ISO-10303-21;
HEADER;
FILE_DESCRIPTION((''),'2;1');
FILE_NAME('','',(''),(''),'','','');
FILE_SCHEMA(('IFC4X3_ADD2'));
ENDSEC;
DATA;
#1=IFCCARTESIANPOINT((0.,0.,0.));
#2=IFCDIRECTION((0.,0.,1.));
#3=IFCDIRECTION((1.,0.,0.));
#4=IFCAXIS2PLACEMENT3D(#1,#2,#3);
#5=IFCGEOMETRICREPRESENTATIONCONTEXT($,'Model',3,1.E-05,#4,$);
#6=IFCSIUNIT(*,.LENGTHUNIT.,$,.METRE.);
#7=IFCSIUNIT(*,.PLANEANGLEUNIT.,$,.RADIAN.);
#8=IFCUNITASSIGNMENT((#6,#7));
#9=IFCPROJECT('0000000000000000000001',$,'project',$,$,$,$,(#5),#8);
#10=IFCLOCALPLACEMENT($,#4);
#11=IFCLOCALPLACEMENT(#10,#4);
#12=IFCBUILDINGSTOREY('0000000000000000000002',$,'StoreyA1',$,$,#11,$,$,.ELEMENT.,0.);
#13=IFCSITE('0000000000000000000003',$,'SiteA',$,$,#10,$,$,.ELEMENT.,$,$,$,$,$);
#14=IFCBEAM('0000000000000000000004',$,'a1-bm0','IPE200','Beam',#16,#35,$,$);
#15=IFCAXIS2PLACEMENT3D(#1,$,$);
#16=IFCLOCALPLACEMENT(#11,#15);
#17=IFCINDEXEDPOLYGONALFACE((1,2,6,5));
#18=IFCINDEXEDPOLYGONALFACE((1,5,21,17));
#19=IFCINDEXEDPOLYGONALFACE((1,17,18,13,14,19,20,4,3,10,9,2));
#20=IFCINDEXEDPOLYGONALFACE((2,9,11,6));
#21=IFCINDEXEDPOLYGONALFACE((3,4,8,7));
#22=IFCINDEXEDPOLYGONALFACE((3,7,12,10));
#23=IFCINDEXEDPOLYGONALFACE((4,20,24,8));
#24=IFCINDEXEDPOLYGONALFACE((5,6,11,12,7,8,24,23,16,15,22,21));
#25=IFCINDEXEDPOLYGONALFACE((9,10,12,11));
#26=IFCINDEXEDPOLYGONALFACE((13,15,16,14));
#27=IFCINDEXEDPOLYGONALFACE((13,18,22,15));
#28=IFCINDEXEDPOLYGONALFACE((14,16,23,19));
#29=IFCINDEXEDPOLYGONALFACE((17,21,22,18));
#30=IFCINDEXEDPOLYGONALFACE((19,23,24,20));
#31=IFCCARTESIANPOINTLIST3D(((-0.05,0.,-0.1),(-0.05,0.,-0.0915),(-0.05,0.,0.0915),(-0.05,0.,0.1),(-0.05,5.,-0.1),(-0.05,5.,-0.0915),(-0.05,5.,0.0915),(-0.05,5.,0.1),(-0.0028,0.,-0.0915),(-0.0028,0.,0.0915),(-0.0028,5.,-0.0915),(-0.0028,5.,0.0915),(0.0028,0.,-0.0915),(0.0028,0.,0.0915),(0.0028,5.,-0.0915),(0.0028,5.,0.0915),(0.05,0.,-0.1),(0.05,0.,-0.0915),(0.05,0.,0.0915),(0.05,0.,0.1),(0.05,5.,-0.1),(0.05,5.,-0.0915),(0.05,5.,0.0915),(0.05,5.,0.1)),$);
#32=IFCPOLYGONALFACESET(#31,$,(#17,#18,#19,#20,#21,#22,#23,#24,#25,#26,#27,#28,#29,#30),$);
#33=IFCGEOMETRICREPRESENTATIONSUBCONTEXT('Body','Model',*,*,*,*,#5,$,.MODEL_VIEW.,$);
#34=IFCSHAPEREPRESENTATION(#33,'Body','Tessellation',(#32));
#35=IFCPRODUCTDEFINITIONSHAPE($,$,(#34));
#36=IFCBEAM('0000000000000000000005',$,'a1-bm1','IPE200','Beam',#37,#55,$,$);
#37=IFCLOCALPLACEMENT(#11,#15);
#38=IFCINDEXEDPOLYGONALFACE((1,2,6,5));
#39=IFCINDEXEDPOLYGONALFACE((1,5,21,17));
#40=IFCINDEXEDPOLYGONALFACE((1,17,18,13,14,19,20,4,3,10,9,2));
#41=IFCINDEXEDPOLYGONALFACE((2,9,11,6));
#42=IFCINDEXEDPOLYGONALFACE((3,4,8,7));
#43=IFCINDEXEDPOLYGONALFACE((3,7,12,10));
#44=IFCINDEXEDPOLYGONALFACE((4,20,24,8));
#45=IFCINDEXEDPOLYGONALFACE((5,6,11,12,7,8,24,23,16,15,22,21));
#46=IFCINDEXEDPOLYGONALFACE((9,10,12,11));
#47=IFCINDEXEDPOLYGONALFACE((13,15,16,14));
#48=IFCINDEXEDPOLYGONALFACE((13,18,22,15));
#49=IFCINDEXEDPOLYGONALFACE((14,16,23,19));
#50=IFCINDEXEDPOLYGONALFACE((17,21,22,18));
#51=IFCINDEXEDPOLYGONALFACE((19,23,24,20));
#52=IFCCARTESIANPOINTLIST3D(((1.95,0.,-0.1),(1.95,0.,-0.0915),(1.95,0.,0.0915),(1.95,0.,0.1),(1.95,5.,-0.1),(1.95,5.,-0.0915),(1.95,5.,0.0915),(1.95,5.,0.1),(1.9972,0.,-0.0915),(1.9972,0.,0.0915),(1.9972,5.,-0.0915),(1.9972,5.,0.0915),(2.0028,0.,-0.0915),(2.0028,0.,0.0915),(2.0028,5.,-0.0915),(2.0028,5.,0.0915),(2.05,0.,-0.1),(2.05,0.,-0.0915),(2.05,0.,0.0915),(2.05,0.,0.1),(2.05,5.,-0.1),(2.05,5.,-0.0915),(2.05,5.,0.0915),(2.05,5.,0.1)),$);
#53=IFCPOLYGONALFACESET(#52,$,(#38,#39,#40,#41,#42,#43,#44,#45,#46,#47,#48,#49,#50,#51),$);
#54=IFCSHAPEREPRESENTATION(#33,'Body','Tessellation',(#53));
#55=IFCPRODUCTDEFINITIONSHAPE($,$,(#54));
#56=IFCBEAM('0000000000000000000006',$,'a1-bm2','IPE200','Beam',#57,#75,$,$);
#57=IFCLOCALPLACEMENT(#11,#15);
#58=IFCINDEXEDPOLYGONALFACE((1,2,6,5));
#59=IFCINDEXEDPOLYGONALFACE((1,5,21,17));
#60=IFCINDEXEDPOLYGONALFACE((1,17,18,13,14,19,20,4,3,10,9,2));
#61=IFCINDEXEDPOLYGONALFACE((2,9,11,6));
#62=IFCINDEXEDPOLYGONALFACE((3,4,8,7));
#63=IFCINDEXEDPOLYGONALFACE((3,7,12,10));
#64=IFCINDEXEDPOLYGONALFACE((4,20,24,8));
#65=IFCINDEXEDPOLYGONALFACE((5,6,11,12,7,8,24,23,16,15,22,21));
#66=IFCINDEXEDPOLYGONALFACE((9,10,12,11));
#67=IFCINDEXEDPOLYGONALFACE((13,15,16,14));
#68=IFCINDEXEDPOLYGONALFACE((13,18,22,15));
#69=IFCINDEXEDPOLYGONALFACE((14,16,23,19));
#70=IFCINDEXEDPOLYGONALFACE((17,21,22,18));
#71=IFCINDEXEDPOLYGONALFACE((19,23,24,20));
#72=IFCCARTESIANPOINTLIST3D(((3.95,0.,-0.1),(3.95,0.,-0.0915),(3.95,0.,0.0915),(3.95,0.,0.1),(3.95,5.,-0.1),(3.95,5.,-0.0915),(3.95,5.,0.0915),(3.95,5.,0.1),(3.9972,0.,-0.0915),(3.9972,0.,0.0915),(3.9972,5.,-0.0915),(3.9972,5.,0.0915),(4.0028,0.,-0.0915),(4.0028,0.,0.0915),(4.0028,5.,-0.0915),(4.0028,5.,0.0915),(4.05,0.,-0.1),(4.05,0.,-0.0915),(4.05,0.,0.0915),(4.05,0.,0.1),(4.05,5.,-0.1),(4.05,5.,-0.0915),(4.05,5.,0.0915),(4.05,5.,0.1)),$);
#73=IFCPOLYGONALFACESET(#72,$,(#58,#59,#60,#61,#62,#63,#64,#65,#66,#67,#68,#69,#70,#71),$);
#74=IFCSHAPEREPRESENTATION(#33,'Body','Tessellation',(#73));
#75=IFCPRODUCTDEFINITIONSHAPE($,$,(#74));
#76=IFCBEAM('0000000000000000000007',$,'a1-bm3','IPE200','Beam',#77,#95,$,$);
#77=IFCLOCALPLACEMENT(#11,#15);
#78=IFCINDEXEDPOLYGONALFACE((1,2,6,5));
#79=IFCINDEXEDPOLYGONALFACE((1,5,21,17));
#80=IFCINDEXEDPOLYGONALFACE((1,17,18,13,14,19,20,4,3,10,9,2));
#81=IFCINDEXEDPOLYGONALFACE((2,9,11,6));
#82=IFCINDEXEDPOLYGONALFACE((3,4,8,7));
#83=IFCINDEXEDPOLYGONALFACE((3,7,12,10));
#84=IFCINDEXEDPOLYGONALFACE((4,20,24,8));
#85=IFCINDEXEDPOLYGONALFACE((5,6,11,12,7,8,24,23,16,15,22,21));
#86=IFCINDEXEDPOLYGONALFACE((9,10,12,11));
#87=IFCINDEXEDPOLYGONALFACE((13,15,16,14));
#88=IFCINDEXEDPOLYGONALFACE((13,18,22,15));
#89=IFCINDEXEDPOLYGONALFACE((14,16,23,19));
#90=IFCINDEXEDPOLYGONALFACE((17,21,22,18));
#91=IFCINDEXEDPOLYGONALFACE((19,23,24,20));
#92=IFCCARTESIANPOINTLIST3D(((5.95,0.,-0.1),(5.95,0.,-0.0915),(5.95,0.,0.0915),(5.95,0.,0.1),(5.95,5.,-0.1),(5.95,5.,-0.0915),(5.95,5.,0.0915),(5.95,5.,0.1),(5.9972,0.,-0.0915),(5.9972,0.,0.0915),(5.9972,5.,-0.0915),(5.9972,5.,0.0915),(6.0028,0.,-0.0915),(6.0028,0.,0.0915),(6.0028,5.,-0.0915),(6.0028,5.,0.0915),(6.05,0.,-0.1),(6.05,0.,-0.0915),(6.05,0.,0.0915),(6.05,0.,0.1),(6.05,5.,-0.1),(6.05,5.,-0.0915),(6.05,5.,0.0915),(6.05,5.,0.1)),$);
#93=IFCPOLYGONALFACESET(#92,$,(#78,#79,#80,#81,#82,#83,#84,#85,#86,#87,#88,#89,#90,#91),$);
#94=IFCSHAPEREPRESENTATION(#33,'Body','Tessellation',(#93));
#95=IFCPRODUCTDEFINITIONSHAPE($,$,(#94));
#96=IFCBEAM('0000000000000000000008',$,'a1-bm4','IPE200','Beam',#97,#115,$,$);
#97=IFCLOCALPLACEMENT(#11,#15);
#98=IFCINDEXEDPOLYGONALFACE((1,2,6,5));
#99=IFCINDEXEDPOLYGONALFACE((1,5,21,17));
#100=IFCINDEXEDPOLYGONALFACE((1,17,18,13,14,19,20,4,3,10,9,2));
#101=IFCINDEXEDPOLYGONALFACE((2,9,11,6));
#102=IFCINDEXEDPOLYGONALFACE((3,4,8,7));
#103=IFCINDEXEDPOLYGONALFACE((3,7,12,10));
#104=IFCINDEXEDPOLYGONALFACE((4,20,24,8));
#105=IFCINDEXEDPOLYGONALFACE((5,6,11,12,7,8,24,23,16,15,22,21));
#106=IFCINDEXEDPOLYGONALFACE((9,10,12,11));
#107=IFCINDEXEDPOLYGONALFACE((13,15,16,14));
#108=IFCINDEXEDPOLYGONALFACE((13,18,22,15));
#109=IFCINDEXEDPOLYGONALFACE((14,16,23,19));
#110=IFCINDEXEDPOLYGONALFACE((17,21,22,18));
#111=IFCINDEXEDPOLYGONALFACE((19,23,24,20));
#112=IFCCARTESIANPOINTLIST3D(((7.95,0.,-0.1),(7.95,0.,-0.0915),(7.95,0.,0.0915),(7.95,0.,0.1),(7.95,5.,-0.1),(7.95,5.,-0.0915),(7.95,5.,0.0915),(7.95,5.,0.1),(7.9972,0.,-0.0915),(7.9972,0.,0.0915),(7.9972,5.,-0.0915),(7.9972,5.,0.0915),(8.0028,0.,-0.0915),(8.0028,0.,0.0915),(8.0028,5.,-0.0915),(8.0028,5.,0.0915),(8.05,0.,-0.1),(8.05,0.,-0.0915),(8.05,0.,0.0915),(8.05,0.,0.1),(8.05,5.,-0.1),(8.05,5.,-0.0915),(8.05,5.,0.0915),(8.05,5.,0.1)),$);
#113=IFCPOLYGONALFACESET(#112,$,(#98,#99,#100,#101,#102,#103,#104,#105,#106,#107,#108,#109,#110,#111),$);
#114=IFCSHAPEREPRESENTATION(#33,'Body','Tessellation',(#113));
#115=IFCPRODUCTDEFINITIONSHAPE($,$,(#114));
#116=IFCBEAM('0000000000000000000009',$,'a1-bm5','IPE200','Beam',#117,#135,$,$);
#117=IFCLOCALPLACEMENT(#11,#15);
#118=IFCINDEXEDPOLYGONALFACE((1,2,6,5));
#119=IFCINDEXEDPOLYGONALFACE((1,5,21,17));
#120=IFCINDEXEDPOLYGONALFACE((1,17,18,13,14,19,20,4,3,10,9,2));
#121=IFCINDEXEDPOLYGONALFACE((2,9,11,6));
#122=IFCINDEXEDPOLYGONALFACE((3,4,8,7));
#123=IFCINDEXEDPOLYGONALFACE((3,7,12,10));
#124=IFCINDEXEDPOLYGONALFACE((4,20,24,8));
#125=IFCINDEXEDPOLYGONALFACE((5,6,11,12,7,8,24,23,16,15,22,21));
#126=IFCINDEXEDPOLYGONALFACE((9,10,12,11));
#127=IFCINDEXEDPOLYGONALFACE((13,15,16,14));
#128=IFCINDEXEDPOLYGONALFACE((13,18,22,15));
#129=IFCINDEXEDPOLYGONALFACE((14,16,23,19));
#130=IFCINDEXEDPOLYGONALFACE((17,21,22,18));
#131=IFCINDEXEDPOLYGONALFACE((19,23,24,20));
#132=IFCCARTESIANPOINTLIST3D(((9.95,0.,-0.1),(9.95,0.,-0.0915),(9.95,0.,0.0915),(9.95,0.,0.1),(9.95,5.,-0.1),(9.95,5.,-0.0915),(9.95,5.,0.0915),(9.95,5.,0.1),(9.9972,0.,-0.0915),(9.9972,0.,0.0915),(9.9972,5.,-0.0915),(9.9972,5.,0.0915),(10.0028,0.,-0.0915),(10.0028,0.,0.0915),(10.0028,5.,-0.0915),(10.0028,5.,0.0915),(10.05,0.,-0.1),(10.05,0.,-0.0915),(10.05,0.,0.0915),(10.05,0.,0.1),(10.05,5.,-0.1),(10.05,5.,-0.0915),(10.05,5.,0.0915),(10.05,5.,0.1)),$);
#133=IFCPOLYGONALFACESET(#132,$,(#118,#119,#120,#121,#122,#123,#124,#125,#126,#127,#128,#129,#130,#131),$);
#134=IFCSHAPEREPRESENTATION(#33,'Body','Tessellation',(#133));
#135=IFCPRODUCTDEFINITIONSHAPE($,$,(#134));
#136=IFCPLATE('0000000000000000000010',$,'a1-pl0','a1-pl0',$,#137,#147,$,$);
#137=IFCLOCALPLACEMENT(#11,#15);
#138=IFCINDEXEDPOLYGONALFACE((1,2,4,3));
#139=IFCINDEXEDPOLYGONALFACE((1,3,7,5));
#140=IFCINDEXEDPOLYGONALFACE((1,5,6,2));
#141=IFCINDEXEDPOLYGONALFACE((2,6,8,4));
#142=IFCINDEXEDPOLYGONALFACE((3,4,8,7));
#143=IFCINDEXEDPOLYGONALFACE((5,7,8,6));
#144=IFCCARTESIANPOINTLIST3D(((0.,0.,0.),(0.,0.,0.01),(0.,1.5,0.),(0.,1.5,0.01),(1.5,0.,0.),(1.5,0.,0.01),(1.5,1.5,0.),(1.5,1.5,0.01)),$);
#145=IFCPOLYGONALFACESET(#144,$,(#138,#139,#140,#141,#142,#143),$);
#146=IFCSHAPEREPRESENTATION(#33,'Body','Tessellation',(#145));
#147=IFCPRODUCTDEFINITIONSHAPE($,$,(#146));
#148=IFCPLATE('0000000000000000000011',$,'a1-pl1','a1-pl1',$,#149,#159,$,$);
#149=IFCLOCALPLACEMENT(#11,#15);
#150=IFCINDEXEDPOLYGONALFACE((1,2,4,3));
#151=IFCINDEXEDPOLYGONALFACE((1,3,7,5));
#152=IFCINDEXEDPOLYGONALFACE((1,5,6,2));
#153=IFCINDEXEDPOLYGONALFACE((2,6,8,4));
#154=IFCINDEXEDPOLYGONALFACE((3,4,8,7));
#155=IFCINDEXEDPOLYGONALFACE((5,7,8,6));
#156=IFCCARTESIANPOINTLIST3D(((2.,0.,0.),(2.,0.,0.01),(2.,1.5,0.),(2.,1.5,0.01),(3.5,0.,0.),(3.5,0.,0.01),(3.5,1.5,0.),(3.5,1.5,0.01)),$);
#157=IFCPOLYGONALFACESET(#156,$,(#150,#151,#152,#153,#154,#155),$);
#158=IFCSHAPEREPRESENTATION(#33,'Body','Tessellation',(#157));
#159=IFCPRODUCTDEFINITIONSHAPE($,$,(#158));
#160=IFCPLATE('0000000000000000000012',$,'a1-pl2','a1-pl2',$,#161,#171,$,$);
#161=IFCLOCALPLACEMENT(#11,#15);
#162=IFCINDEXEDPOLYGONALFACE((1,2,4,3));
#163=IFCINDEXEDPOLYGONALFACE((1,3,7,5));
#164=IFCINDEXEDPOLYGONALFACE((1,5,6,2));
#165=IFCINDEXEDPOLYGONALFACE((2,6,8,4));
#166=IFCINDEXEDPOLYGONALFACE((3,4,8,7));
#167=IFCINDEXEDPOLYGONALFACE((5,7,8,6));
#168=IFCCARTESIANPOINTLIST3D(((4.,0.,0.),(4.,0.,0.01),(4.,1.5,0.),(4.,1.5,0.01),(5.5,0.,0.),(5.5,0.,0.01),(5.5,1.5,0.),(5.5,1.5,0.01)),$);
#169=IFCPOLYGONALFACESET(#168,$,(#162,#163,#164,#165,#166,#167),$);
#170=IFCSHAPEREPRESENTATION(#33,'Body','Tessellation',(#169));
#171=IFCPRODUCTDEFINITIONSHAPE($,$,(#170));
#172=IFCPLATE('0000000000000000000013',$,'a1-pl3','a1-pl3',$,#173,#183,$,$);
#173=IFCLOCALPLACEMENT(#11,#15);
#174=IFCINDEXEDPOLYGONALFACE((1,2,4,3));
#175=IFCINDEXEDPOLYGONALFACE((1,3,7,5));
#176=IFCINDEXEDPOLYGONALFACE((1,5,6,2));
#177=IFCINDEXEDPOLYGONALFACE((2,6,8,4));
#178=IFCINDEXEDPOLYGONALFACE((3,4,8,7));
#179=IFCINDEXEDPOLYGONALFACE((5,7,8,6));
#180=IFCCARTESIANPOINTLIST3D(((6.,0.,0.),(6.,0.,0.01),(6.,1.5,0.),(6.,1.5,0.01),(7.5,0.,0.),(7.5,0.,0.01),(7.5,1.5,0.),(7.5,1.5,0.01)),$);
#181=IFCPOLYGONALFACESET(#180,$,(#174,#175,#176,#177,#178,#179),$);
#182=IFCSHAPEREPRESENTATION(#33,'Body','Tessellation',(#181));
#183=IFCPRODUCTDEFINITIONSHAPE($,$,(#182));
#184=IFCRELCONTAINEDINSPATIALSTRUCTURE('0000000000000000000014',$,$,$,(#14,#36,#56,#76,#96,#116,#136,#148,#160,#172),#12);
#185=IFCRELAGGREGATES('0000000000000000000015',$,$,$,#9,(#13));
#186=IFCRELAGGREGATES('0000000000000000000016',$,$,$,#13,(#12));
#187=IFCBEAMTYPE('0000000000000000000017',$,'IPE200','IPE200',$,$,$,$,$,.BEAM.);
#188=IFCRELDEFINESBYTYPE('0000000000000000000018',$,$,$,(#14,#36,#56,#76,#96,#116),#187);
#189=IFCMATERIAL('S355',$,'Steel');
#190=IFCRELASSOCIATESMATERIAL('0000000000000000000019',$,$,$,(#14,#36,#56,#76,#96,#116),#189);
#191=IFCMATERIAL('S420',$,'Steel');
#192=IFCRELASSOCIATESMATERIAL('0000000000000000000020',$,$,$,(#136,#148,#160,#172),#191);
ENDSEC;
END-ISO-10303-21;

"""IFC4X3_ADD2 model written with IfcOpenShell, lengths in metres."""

from ifc_helpers import new_model, si_unit, frame, origin_with_axes, place, context, subcontext, project, spatial, line, indexed_curve, i_section, outline, extrude, material, material_profile, profile_set, profile_usage, type_object, element, save


model = new_model("IFC4X3_ADD2")

# Units and contexts
model_context = context("Model", 3, precision=1e-05, world=origin_with_axes())
body_context = subcontext(model_context, "Body", "Model", "MODEL_VIEW")
ifc_project = project(units=[si_unit("LENGTHUNIT", "METRE"), si_unit("PLANEANGLEUNIT", "RADIAN")], contexts=[model_context])

# Site, storey
site_placement = place(None, origin_with_axes())
site = spatial("IfcSite", under=ifc_project, at=site_placement, Name="SiteA", CompositionType="ELEMENT")
storey_placement = place(site_placement, origin_with_axes())
storey = spatial("IfcBuildingStorey", under=site, at=storey_placement, Name="StoreyA1", CompositionType="ELEMENT", Elevation=0.0)

# Beams
ifc_material_1 = material(Name="S355", Category="Steel")
ifc_material_profile_1 = material_profile(ifc_material_1, i_section(OverallWidth=0.1, OverallDepth=0.2, WebThickness=0.0056, FlangeThickness=0.0085), Name="IPE200", Category="LoadBearing")
ifc_profile_set_1 = profile_set([ifc_material_profile_1], Name="IPE200")
ifc_profile_usage_1 = profile_usage(ifc_profile_set_1, cardinal=5)
beam_type = type_object("IfcBeamType", Name="IPE200", Description="IPE200", PredefinedType="BEAM")
placement_1 = place(storey_placement, origin_with_axes())
beam_1_placement = place(placement_1, origin_with_axes())
element("IfcBeam", 1, at=beam_1_placement, inside=storey, type_object=beam_type, material=ifc_profile_usage_1, Name="a1-bm0", Description="IPE200", ObjectType="Beam", context=body_context, shape_type="SolidModel", body=[
    extrude(i_section(OverallWidth=0.1, OverallDepth=0.2, WebThickness=0.0056, FlangeThickness=0.0085), frame((0.0, 0.0, 0.0), z_axis=(0.0, 1.0, 0.0), x_axis=(-1.0, 0.0, 0.0)), (0.0, 0.0, 1.0), 5.0),
])
ifc_material_profile_2 = material_profile(ifc_material_1, i_section(OverallWidth=0.1, OverallDepth=0.2, WebThickness=0.0056, FlangeThickness=0.0085), Name="IPE200", Category="LoadBearing")
ifc_profile_set_2 = profile_set([ifc_material_profile_2], Name="IPE200")
ifc_profile_usage_2 = profile_usage(ifc_profile_set_2, cardinal=5)
placement_2 = place(storey_placement, origin_with_axes())
beam_2_placement = place(placement_2, origin_with_axes())
element("IfcBeam", 2, at=beam_2_placement, inside=storey, type_object=beam_type, material=ifc_profile_usage_2, Name="a1-bm1", Description="IPE200", ObjectType="Beam", context=body_context, shape_type="SolidModel", body=[
    extrude(i_section(OverallWidth=0.1, OverallDepth=0.2, WebThickness=0.0056, FlangeThickness=0.0085), frame((2.0, 0.0, 0.0), z_axis=(0.0, 1.0, 0.0), x_axis=(-1.0, 0.0, 0.0)), (0.0, 0.0, 1.0), 5.0),
])
ifc_material_profile_3 = material_profile(ifc_material_1, i_section(OverallWidth=0.1, OverallDepth=0.2, WebThickness=0.0056, FlangeThickness=0.0085), Name="IPE200", Category="LoadBearing")
ifc_profile_set_3 = profile_set([ifc_material_profile_3], Name="IPE200")
ifc_profile_usage_3 = profile_usage(ifc_profile_set_3, cardinal=5)
placement_3 = place(storey_placement, origin_with_axes())
beam_3_placement = place(placement_3, origin_with_axes())
element("IfcBeam", 3, at=beam_3_placement, inside=storey, type_object=beam_type, material=ifc_profile_usage_3, Name="a1-bm2", Description="IPE200", ObjectType="Beam", context=body_context, shape_type="SolidModel", body=[
    extrude(i_section(OverallWidth=0.1, OverallDepth=0.2, WebThickness=0.0056, FlangeThickness=0.0085), frame((4.0, 0.0, 0.0), z_axis=(0.0, 1.0, 0.0), x_axis=(-1.0, 0.0, 0.0)), (0.0, 0.0, 1.0), 5.0),
])
ifc_material_profile_4 = material_profile(ifc_material_1, i_section(OverallWidth=0.1, OverallDepth=0.2, WebThickness=0.0056, FlangeThickness=0.0085), Name="IPE200", Category="LoadBearing")
ifc_profile_set_4 = profile_set([ifc_material_profile_4], Name="IPE200")
ifc_profile_usage_4 = profile_usage(ifc_profile_set_4, cardinal=5)
placement_4 = place(storey_placement, origin_with_axes())
beam_4_placement = place(placement_4, origin_with_axes())
element("IfcBeam", 4, at=beam_4_placement, inside=storey, type_object=beam_type, material=ifc_profile_usage_4, Name="a1-bm3", Description="IPE200", ObjectType="Beam", context=body_context, shape_type="SolidModel", body=[
    extrude(i_section(OverallWidth=0.1, OverallDepth=0.2, WebThickness=0.0056, FlangeThickness=0.0085), frame((6.0, 0.0, 0.0), z_axis=(0.0, 1.0, 0.0), x_axis=(-1.0, 0.0, 0.0)), (0.0, 0.0, 1.0), 5.0),
])
ifc_material_profile_5 = material_profile(ifc_material_1, i_section(OverallWidth=0.1, OverallDepth=0.2, WebThickness=0.0056, FlangeThickness=0.0085), Name="IPE200", Category="LoadBearing")
ifc_profile_set_5 = profile_set([ifc_material_profile_5], Name="IPE200")
ifc_profile_usage_5 = profile_usage(ifc_profile_set_5, cardinal=5)
placement_5 = place(storey_placement, origin_with_axes())
beam_5_placement = place(placement_5, origin_with_axes())
element("IfcBeam", 5, at=beam_5_placement, inside=storey, type_object=beam_type, material=ifc_profile_usage_5, Name="a1-bm4", Description="IPE200", ObjectType="Beam", context=body_context, shape_type="SolidModel", body=[
    extrude(i_section(OverallWidth=0.1, OverallDepth=0.2, WebThickness=0.0056, FlangeThickness=0.0085), frame((8.0, 0.0, 0.0), z_axis=(0.0, 1.0, 0.0), x_axis=(-1.0, 0.0, 0.0)), (0.0, 0.0, 1.0), 5.0),
])
ifc_material_profile_6 = material_profile(ifc_material_1, i_section(OverallWidth=0.1, OverallDepth=0.2, WebThickness=0.0056, FlangeThickness=0.0085), Name="IPE200", Category="LoadBearing")
ifc_profile_set_6 = profile_set([ifc_material_profile_6], Name="IPE200")
ifc_profile_usage_6 = profile_usage(ifc_profile_set_6, cardinal=5)
placement_6 = place(storey_placement, origin_with_axes())
beam_6_placement = place(placement_6, origin_with_axes())
element("IfcBeam", 6, at=beam_6_placement, inside=storey, type_object=beam_type, material=ifc_profile_usage_6, Name="a1-bm5", Description="IPE200", ObjectType="Beam", context=body_context, shape_type="SolidModel", body=[
    extrude(i_section(OverallWidth=0.1, OverallDepth=0.2, WebThickness=0.0056, FlangeThickness=0.0085), frame((10.0, 0.0, 0.0), z_axis=(0.0, 1.0, 0.0), x_axis=(-1.0, 0.0, 0.0)), (0.0, 0.0, 1.0), 5.0),
])

# Plates
ifc_material_2 = material(Name="S420", Category="Steel")
plate_1_placement = place(None, origin_with_axes())
element("IfcPlate", 7, at=plate_1_placement, inside=storey, material=ifc_material_2, Name="a1-pl0", Description="a1-pl0", context=body_context, shape_type="SolidModel", body=[
    extrude(outline(indexed_curve([(0.0, 0.0), (0.0, 1.5), (1.5, 0.0), (1.5, 1.5)], segments=[line(3, 1), line(1, 2), line(2, 4), line(4, 3)])), origin_with_axes(), (0.0, 0.0, 1.0), 0.01),
])
plate_2_placement = place(None, origin_with_axes())
element("IfcPlate", 8, at=plate_2_placement, inside=storey, material=ifc_material_2, Name="a1-pl1", Description="a1-pl1", context=body_context, shape_type="SolidModel", body=[
    extrude(outline(indexed_curve([(2.0, 0.0), (2.0, 1.5), (3.5, 0.0), (3.5, 1.5)], segments=[line(3, 1), line(1, 2), line(2, 4), line(4, 3)])), origin_with_axes(), (0.0, 0.0, 1.0), 0.01),
])
plate_3_placement = place(None, origin_with_axes())
element("IfcPlate", 9, at=plate_3_placement, inside=storey, material=ifc_material_2, Name="a1-pl2", Description="a1-pl2", context=body_context, shape_type="SolidModel", body=[
    extrude(outline(indexed_curve([(4.0, 0.0), (4.0, 1.5), (5.5, 0.0), (5.5, 1.5)], segments=[line(3, 1), line(1, 2), line(2, 4), line(4, 3)])), origin_with_axes(), (0.0, 0.0, 1.0), 0.01),
])
plate_4_placement = place(None, origin_with_axes())
element("IfcPlate", 10, at=plate_4_placement, inside=storey, material=ifc_material_2, Name="a1-pl3", Description="a1-pl3", context=body_context, shape_type="SolidModel", body=[
    extrude(outline(indexed_curve([(6.0, 0.0), (6.0, 1.5), (7.5, 0.0), (7.5, 1.5)], segments=[line(3, 1), line(1, 2), line(2, 4), line(4, 3)])), origin_with_axes(), (0.0, 0.0, 1.0), 0.01),
])

save(model, "model.ifc")
